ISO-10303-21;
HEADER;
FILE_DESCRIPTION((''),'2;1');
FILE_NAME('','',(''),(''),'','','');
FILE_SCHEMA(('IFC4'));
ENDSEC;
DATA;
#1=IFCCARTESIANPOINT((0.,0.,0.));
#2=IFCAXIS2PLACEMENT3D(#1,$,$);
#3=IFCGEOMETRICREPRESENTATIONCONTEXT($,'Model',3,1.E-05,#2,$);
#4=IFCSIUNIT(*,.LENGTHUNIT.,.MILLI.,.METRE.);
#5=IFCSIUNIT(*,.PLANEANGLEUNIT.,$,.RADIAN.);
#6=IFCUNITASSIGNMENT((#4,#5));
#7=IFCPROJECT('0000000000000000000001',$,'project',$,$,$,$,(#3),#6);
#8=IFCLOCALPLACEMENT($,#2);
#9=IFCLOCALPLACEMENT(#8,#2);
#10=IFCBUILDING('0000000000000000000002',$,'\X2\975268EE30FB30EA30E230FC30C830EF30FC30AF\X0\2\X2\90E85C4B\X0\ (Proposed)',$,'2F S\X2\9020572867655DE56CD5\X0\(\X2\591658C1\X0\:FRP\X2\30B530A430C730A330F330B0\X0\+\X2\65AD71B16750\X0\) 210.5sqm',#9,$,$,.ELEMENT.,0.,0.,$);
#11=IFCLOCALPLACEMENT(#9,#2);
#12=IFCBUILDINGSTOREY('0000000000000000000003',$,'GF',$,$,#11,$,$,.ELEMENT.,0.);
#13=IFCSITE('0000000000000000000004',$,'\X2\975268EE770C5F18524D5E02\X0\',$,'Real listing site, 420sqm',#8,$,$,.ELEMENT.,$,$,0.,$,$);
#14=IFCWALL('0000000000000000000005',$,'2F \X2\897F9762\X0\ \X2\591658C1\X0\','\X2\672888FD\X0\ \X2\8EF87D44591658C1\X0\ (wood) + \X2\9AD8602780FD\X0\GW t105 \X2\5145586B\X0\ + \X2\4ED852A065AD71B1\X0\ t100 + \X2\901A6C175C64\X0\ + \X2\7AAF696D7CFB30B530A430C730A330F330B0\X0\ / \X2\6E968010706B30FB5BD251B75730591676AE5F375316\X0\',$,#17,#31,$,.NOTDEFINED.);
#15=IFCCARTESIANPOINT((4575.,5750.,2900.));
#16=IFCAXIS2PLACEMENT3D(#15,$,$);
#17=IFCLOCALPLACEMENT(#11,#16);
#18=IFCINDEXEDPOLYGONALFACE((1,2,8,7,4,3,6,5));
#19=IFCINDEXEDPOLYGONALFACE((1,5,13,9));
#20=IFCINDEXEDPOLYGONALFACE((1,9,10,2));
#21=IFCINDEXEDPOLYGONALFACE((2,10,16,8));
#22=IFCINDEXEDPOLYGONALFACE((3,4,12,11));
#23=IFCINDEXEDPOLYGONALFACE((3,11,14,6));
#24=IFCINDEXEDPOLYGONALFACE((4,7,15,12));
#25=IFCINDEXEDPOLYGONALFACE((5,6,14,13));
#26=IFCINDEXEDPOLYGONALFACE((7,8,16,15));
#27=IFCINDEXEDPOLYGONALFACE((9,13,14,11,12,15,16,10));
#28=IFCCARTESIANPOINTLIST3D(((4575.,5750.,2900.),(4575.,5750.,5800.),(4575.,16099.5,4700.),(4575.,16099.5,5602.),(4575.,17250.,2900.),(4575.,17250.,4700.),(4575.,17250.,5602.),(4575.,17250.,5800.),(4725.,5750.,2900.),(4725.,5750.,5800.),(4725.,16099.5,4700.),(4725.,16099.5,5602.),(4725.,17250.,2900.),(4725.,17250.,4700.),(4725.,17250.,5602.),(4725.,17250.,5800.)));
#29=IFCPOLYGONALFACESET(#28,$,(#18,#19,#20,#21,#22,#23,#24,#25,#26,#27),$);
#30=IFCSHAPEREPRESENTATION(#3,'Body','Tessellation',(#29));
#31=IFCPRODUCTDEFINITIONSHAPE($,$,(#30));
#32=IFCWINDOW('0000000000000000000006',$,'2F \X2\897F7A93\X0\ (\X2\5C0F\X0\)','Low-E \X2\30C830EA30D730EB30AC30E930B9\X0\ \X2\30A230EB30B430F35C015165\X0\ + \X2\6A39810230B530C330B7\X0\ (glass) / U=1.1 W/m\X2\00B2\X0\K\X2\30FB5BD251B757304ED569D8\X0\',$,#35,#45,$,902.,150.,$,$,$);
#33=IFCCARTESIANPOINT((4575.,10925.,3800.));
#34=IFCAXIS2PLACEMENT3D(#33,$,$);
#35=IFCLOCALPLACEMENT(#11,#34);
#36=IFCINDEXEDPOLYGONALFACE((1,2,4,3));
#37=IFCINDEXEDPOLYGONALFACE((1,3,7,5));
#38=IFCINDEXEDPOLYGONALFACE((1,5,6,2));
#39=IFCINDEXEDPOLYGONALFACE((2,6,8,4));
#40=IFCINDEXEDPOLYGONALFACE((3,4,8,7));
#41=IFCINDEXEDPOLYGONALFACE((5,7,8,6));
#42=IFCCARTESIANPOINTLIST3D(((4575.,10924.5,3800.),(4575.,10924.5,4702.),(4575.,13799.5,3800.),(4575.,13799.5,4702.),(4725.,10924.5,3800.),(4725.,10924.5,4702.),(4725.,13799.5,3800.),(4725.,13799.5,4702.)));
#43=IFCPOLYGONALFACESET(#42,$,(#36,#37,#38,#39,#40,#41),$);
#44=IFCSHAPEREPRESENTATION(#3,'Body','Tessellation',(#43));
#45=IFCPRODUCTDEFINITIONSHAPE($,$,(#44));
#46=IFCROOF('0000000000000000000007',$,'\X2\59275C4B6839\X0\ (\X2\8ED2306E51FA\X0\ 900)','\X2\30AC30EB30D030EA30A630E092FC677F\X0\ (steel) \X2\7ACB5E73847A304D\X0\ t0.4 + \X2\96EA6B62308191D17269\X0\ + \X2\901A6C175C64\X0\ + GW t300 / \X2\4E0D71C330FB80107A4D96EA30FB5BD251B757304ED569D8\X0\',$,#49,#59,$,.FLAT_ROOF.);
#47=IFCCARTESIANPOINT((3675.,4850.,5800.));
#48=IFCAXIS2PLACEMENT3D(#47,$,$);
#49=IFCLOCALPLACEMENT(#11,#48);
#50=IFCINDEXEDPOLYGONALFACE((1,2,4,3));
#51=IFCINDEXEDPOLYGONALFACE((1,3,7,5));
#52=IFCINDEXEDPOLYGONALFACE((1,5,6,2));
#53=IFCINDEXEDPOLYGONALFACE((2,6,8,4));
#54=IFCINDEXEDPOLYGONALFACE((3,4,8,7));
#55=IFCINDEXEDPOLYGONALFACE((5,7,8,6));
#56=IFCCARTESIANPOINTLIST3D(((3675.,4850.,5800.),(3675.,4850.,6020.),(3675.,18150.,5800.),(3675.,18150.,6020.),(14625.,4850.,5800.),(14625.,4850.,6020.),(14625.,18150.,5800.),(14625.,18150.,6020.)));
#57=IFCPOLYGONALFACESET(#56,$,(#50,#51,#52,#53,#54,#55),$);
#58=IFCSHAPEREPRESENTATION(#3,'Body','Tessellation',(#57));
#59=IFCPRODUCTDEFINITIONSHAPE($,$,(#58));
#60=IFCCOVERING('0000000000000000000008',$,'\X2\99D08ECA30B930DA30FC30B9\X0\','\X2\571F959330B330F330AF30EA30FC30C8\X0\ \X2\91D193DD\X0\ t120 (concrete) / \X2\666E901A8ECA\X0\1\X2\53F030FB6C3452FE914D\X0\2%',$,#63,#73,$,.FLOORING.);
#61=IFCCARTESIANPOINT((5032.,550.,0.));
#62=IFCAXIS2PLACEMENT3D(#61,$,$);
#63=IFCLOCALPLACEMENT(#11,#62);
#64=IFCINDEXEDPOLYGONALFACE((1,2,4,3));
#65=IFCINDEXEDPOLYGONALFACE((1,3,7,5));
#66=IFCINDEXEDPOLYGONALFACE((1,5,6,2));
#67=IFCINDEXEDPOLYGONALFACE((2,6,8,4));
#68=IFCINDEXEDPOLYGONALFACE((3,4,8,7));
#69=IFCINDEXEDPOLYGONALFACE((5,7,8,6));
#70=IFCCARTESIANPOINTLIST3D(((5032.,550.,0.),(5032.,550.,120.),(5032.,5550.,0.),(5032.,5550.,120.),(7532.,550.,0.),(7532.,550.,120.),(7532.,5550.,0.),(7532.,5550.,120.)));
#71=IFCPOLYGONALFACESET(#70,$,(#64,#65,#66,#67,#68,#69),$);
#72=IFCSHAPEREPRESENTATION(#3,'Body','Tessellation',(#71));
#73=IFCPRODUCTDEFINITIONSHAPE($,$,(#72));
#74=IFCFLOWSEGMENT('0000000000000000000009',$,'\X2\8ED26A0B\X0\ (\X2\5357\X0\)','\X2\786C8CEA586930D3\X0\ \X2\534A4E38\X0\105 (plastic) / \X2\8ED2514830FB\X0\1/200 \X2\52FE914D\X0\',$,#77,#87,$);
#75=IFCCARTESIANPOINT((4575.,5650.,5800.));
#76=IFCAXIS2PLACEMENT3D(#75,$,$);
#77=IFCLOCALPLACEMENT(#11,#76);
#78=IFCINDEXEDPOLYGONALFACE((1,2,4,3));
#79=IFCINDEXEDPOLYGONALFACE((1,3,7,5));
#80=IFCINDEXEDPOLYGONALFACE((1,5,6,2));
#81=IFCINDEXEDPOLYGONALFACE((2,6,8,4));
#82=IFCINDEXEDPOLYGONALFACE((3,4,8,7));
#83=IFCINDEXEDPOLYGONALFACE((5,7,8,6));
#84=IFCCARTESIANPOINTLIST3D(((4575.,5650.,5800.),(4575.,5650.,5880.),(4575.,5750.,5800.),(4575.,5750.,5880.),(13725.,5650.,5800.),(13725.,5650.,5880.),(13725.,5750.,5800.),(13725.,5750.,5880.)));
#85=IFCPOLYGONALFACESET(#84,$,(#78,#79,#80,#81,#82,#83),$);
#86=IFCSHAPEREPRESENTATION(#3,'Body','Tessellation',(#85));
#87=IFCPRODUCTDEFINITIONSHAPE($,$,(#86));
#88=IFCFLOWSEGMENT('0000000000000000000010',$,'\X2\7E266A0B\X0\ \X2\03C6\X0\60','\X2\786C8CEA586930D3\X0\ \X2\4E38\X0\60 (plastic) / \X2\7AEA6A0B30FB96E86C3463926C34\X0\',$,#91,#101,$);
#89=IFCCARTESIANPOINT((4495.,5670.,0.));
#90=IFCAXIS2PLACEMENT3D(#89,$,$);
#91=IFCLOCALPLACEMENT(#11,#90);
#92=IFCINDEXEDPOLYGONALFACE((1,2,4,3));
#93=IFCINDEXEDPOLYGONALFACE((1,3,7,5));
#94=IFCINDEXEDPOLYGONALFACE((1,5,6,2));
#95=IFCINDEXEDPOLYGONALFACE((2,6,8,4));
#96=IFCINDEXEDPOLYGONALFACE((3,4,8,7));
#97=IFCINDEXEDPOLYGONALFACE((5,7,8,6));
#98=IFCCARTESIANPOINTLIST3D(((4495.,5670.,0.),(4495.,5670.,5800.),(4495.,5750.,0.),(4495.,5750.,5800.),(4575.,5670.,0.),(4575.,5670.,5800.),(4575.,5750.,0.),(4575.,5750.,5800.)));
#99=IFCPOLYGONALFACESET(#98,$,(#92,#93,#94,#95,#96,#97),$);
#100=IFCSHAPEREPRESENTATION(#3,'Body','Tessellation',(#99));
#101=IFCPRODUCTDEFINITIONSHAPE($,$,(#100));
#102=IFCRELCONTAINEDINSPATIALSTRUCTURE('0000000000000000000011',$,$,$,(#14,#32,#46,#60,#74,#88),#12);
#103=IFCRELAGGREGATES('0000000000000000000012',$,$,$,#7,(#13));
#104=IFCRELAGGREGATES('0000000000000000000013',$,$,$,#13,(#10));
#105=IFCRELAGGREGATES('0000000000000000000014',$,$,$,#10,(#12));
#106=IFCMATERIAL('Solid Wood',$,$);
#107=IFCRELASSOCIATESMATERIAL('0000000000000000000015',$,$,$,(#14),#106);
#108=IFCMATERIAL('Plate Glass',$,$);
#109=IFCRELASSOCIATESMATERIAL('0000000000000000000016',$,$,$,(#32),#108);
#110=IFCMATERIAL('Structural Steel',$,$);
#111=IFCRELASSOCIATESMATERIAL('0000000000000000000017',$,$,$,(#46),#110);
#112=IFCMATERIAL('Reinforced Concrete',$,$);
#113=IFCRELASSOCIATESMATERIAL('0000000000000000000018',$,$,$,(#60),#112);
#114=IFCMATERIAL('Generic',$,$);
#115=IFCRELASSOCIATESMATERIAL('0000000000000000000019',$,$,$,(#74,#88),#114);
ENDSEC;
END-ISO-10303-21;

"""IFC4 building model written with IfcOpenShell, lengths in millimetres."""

from ifc_helpers import new_model, si_unit, frame, frame_2d, origin, place, context, project, spatial, rectangle, extrude, material, element, fill, save


model = new_model("IFC4")

# Units and contexts
model_context = context("Model", 3, precision=1e-05, world=origin())
ifc_project = project(units=[si_unit("LENGTHUNIT", "METRE", prefix="MILLI"), si_unit("PLANEANGLEUNIT", "RADIAN")], contexts=[model_context])

# Site, building, storey
site_placement = place(None, origin())
site = spatial("IfcSite", under=ifc_project, at=site_placement, Name="青森県弘前市", ObjectType="Real listing site, 420sqm", CompositionType="ELEMENT", RefElevation=0.0)
building_placement = place(site_placement, origin())
building = spatial("IfcBuilding", under=site, at=building_placement, Name="青森・リモートワーク2部屋 (Proposed)", ObjectType="2F S造在来工法(外壁:FRPサイディング+断熱材) 210.5sqm", CompositionType="ELEMENT", ElevationOfRefHeight=0.0, ElevationOfTerrain=0.0)
storey_placement = place(building_placement, origin())
storey = spatial("IfcBuildingStorey", under=building, at=storey_placement, Name="GF", CompositionType="ELEMENT", Elevation=0.0)

# Shared definitions
ifc_material_1 = material(Name="Solid Wood")

# Shared definitions
ifc_material_2 = material(Name="Reinforced Concrete")

# Shared definitions
ifc_material_3 = material(Name="Plate Glass")

# Wall, opening, window
wall_1_placement = place(storey_placement, frame((4575.0, 5750.0, 2900.0)))
wall_1 = element("IfcWall", 1, at=wall_1_placement, inside=storey, material=ifc_material_1, Name="2F 西面 外壁", Description="木製 軸組外壁 (wood) + 高性能GW t105 充填 + 付加断熱 t100 + 通気層 + 窯業系サイディング / 準耐火・寒冷地外皮強化", PredefinedType="NOTDEFINED", context=model_context, shape_type="SweptSolid", body=[
    extrude(rectangle(XDim=150.0, YDim=11500.0, at=frame_2d((75.0, 5750.0))), frame((4575.0, 5750.0, 2900.0)), (0.0, 0.0, 1.0), 2900.0),
])
opening_1_placement = place(storey_placement, frame((4575.0, 10925.0, 3800.0)))
opening_1 = element("IfcOpeningElement", 2, at=opening_1_placement, cuts=wall_1, PredefinedType="NOTDEFINED", context=model_context, shape_type="SweptSolid", body=[
    extrude(rectangle(XDim=150.0, YDim=2875.0, at=frame_2d((75.0, 1437.0))), frame((4575.0, 10925.0, 3800.0)), (0.0, 0.0, 1.0), 902.0),
])
window_1_placement = place(storey_placement, frame((4575.0, 10925.0, 3800.0)))
window_1 = element("IfcWindow", 3, at=window_1_placement, inside=storey, material=ifc_material_3, Name="2F 西窓 (小)", Description="Low-E トリプルガラス アルゴン封入 + 樹脂サッシ (glass) / U=1.1 W/m²K・寒冷地仕様", OverallHeight=902.0, OverallWidth=150.0, context=model_context, shape_type="SweptSolid", body=[
    extrude(rectangle(XDim=150.0, YDim=2875.0, at=frame_2d((75.0, 1437.0))), frame((4575.0, 10925.0, 3800.0)), (0.0, 0.0, 1.0), 902.0),
])
fill(opening_1, window_1)

# Roof
ifc_material_4 = material(Name="Structural Steel")
roof_placement = place(storey_placement, frame((3675.0, 4850.0, 5800.0)))
element("IfcRoof", 4, at=roof_placement, inside=storey, material=ifc_material_4, Name="大屋根 (軒の出 900)", Description="ガルバリウム鋼板 (steel) 立平葺き t0.4 + 雪止め金物 + 通気層 + GW t300 / 不燃・耐積雪・寒冷地仕様", PredefinedType="FLAT_ROOF", context=model_context, shape_type="SweptSolid", body=[
    extrude(rectangle(XDim=10950.0, YDim=13300.0, at=frame_2d((5475.0, 6650.0))), frame((3675.0, 4850.0, 5800.0)), (0.0, 0.0, 1.0), 220.0),
])

# Covering
covering_placement = place(storey_placement, frame((5032.0, 550.0, 0.0)))
element("IfcCovering", 5, at=covering_placement, inside=storey, material=ifc_material_2, Name="駐車スペース", Description="土間コンクリート 金鏝 t120 (concrete) / 普通車1台・水勾配2%", PredefinedType="FLOORING", context=model_context, shape_type="SweptSolid", body=[
    extrude(rectangle(XDim=2500.0, YDim=5000.0, at=frame_2d((1250.0, 2500.0))), frame((5032.0, 550.0, 0.0)), (0.0, 0.0, 1.0), 120.0),
])

# Flow segments
ifc_material_5 = material(Name="Generic")
flow_segment_1_placement = place(storey_placement, frame((4575.0, 5650.0, 5800.0)))
element("IfcFlowSegment", 6, at=flow_segment_1_placement, inside=storey, material=ifc_material_5, Name="軒樋 (南)", Description="硬質塩ビ 半丸105 (plastic) / 軒先・1/200 勾配", context=model_context, shape_type="SweptSolid", body=[
    extrude(rectangle(XDim=9150.0, YDim=100.0, at=frame_2d((4575.0, 50.0))), frame((4575.0, 5650.0, 5800.0)), (0.0, 0.0, 1.0), 80.0),
])
flow_segment_2_placement = place(storey_placement, frame((4495.0, 5670.0, 0.0)))
element("IfcFlowSegment", 7, at=flow_segment_2_placement, inside=storey, material=ifc_material_5, Name="縦樋 φ60", Description="硬質塩ビ 丸60 (plastic) / 竪樋・雨水排水", context=model_context, shape_type="SweptSolid", body=[
    extrude(rectangle(XDim=80.0, YDim=80.0, at=frame_2d((40.0, 40.0))), frame((4495.0, 5670.0, 0.0)), (0.0, 0.0, 1.0), 5800.0),
])

save(model, "model.ifc")
